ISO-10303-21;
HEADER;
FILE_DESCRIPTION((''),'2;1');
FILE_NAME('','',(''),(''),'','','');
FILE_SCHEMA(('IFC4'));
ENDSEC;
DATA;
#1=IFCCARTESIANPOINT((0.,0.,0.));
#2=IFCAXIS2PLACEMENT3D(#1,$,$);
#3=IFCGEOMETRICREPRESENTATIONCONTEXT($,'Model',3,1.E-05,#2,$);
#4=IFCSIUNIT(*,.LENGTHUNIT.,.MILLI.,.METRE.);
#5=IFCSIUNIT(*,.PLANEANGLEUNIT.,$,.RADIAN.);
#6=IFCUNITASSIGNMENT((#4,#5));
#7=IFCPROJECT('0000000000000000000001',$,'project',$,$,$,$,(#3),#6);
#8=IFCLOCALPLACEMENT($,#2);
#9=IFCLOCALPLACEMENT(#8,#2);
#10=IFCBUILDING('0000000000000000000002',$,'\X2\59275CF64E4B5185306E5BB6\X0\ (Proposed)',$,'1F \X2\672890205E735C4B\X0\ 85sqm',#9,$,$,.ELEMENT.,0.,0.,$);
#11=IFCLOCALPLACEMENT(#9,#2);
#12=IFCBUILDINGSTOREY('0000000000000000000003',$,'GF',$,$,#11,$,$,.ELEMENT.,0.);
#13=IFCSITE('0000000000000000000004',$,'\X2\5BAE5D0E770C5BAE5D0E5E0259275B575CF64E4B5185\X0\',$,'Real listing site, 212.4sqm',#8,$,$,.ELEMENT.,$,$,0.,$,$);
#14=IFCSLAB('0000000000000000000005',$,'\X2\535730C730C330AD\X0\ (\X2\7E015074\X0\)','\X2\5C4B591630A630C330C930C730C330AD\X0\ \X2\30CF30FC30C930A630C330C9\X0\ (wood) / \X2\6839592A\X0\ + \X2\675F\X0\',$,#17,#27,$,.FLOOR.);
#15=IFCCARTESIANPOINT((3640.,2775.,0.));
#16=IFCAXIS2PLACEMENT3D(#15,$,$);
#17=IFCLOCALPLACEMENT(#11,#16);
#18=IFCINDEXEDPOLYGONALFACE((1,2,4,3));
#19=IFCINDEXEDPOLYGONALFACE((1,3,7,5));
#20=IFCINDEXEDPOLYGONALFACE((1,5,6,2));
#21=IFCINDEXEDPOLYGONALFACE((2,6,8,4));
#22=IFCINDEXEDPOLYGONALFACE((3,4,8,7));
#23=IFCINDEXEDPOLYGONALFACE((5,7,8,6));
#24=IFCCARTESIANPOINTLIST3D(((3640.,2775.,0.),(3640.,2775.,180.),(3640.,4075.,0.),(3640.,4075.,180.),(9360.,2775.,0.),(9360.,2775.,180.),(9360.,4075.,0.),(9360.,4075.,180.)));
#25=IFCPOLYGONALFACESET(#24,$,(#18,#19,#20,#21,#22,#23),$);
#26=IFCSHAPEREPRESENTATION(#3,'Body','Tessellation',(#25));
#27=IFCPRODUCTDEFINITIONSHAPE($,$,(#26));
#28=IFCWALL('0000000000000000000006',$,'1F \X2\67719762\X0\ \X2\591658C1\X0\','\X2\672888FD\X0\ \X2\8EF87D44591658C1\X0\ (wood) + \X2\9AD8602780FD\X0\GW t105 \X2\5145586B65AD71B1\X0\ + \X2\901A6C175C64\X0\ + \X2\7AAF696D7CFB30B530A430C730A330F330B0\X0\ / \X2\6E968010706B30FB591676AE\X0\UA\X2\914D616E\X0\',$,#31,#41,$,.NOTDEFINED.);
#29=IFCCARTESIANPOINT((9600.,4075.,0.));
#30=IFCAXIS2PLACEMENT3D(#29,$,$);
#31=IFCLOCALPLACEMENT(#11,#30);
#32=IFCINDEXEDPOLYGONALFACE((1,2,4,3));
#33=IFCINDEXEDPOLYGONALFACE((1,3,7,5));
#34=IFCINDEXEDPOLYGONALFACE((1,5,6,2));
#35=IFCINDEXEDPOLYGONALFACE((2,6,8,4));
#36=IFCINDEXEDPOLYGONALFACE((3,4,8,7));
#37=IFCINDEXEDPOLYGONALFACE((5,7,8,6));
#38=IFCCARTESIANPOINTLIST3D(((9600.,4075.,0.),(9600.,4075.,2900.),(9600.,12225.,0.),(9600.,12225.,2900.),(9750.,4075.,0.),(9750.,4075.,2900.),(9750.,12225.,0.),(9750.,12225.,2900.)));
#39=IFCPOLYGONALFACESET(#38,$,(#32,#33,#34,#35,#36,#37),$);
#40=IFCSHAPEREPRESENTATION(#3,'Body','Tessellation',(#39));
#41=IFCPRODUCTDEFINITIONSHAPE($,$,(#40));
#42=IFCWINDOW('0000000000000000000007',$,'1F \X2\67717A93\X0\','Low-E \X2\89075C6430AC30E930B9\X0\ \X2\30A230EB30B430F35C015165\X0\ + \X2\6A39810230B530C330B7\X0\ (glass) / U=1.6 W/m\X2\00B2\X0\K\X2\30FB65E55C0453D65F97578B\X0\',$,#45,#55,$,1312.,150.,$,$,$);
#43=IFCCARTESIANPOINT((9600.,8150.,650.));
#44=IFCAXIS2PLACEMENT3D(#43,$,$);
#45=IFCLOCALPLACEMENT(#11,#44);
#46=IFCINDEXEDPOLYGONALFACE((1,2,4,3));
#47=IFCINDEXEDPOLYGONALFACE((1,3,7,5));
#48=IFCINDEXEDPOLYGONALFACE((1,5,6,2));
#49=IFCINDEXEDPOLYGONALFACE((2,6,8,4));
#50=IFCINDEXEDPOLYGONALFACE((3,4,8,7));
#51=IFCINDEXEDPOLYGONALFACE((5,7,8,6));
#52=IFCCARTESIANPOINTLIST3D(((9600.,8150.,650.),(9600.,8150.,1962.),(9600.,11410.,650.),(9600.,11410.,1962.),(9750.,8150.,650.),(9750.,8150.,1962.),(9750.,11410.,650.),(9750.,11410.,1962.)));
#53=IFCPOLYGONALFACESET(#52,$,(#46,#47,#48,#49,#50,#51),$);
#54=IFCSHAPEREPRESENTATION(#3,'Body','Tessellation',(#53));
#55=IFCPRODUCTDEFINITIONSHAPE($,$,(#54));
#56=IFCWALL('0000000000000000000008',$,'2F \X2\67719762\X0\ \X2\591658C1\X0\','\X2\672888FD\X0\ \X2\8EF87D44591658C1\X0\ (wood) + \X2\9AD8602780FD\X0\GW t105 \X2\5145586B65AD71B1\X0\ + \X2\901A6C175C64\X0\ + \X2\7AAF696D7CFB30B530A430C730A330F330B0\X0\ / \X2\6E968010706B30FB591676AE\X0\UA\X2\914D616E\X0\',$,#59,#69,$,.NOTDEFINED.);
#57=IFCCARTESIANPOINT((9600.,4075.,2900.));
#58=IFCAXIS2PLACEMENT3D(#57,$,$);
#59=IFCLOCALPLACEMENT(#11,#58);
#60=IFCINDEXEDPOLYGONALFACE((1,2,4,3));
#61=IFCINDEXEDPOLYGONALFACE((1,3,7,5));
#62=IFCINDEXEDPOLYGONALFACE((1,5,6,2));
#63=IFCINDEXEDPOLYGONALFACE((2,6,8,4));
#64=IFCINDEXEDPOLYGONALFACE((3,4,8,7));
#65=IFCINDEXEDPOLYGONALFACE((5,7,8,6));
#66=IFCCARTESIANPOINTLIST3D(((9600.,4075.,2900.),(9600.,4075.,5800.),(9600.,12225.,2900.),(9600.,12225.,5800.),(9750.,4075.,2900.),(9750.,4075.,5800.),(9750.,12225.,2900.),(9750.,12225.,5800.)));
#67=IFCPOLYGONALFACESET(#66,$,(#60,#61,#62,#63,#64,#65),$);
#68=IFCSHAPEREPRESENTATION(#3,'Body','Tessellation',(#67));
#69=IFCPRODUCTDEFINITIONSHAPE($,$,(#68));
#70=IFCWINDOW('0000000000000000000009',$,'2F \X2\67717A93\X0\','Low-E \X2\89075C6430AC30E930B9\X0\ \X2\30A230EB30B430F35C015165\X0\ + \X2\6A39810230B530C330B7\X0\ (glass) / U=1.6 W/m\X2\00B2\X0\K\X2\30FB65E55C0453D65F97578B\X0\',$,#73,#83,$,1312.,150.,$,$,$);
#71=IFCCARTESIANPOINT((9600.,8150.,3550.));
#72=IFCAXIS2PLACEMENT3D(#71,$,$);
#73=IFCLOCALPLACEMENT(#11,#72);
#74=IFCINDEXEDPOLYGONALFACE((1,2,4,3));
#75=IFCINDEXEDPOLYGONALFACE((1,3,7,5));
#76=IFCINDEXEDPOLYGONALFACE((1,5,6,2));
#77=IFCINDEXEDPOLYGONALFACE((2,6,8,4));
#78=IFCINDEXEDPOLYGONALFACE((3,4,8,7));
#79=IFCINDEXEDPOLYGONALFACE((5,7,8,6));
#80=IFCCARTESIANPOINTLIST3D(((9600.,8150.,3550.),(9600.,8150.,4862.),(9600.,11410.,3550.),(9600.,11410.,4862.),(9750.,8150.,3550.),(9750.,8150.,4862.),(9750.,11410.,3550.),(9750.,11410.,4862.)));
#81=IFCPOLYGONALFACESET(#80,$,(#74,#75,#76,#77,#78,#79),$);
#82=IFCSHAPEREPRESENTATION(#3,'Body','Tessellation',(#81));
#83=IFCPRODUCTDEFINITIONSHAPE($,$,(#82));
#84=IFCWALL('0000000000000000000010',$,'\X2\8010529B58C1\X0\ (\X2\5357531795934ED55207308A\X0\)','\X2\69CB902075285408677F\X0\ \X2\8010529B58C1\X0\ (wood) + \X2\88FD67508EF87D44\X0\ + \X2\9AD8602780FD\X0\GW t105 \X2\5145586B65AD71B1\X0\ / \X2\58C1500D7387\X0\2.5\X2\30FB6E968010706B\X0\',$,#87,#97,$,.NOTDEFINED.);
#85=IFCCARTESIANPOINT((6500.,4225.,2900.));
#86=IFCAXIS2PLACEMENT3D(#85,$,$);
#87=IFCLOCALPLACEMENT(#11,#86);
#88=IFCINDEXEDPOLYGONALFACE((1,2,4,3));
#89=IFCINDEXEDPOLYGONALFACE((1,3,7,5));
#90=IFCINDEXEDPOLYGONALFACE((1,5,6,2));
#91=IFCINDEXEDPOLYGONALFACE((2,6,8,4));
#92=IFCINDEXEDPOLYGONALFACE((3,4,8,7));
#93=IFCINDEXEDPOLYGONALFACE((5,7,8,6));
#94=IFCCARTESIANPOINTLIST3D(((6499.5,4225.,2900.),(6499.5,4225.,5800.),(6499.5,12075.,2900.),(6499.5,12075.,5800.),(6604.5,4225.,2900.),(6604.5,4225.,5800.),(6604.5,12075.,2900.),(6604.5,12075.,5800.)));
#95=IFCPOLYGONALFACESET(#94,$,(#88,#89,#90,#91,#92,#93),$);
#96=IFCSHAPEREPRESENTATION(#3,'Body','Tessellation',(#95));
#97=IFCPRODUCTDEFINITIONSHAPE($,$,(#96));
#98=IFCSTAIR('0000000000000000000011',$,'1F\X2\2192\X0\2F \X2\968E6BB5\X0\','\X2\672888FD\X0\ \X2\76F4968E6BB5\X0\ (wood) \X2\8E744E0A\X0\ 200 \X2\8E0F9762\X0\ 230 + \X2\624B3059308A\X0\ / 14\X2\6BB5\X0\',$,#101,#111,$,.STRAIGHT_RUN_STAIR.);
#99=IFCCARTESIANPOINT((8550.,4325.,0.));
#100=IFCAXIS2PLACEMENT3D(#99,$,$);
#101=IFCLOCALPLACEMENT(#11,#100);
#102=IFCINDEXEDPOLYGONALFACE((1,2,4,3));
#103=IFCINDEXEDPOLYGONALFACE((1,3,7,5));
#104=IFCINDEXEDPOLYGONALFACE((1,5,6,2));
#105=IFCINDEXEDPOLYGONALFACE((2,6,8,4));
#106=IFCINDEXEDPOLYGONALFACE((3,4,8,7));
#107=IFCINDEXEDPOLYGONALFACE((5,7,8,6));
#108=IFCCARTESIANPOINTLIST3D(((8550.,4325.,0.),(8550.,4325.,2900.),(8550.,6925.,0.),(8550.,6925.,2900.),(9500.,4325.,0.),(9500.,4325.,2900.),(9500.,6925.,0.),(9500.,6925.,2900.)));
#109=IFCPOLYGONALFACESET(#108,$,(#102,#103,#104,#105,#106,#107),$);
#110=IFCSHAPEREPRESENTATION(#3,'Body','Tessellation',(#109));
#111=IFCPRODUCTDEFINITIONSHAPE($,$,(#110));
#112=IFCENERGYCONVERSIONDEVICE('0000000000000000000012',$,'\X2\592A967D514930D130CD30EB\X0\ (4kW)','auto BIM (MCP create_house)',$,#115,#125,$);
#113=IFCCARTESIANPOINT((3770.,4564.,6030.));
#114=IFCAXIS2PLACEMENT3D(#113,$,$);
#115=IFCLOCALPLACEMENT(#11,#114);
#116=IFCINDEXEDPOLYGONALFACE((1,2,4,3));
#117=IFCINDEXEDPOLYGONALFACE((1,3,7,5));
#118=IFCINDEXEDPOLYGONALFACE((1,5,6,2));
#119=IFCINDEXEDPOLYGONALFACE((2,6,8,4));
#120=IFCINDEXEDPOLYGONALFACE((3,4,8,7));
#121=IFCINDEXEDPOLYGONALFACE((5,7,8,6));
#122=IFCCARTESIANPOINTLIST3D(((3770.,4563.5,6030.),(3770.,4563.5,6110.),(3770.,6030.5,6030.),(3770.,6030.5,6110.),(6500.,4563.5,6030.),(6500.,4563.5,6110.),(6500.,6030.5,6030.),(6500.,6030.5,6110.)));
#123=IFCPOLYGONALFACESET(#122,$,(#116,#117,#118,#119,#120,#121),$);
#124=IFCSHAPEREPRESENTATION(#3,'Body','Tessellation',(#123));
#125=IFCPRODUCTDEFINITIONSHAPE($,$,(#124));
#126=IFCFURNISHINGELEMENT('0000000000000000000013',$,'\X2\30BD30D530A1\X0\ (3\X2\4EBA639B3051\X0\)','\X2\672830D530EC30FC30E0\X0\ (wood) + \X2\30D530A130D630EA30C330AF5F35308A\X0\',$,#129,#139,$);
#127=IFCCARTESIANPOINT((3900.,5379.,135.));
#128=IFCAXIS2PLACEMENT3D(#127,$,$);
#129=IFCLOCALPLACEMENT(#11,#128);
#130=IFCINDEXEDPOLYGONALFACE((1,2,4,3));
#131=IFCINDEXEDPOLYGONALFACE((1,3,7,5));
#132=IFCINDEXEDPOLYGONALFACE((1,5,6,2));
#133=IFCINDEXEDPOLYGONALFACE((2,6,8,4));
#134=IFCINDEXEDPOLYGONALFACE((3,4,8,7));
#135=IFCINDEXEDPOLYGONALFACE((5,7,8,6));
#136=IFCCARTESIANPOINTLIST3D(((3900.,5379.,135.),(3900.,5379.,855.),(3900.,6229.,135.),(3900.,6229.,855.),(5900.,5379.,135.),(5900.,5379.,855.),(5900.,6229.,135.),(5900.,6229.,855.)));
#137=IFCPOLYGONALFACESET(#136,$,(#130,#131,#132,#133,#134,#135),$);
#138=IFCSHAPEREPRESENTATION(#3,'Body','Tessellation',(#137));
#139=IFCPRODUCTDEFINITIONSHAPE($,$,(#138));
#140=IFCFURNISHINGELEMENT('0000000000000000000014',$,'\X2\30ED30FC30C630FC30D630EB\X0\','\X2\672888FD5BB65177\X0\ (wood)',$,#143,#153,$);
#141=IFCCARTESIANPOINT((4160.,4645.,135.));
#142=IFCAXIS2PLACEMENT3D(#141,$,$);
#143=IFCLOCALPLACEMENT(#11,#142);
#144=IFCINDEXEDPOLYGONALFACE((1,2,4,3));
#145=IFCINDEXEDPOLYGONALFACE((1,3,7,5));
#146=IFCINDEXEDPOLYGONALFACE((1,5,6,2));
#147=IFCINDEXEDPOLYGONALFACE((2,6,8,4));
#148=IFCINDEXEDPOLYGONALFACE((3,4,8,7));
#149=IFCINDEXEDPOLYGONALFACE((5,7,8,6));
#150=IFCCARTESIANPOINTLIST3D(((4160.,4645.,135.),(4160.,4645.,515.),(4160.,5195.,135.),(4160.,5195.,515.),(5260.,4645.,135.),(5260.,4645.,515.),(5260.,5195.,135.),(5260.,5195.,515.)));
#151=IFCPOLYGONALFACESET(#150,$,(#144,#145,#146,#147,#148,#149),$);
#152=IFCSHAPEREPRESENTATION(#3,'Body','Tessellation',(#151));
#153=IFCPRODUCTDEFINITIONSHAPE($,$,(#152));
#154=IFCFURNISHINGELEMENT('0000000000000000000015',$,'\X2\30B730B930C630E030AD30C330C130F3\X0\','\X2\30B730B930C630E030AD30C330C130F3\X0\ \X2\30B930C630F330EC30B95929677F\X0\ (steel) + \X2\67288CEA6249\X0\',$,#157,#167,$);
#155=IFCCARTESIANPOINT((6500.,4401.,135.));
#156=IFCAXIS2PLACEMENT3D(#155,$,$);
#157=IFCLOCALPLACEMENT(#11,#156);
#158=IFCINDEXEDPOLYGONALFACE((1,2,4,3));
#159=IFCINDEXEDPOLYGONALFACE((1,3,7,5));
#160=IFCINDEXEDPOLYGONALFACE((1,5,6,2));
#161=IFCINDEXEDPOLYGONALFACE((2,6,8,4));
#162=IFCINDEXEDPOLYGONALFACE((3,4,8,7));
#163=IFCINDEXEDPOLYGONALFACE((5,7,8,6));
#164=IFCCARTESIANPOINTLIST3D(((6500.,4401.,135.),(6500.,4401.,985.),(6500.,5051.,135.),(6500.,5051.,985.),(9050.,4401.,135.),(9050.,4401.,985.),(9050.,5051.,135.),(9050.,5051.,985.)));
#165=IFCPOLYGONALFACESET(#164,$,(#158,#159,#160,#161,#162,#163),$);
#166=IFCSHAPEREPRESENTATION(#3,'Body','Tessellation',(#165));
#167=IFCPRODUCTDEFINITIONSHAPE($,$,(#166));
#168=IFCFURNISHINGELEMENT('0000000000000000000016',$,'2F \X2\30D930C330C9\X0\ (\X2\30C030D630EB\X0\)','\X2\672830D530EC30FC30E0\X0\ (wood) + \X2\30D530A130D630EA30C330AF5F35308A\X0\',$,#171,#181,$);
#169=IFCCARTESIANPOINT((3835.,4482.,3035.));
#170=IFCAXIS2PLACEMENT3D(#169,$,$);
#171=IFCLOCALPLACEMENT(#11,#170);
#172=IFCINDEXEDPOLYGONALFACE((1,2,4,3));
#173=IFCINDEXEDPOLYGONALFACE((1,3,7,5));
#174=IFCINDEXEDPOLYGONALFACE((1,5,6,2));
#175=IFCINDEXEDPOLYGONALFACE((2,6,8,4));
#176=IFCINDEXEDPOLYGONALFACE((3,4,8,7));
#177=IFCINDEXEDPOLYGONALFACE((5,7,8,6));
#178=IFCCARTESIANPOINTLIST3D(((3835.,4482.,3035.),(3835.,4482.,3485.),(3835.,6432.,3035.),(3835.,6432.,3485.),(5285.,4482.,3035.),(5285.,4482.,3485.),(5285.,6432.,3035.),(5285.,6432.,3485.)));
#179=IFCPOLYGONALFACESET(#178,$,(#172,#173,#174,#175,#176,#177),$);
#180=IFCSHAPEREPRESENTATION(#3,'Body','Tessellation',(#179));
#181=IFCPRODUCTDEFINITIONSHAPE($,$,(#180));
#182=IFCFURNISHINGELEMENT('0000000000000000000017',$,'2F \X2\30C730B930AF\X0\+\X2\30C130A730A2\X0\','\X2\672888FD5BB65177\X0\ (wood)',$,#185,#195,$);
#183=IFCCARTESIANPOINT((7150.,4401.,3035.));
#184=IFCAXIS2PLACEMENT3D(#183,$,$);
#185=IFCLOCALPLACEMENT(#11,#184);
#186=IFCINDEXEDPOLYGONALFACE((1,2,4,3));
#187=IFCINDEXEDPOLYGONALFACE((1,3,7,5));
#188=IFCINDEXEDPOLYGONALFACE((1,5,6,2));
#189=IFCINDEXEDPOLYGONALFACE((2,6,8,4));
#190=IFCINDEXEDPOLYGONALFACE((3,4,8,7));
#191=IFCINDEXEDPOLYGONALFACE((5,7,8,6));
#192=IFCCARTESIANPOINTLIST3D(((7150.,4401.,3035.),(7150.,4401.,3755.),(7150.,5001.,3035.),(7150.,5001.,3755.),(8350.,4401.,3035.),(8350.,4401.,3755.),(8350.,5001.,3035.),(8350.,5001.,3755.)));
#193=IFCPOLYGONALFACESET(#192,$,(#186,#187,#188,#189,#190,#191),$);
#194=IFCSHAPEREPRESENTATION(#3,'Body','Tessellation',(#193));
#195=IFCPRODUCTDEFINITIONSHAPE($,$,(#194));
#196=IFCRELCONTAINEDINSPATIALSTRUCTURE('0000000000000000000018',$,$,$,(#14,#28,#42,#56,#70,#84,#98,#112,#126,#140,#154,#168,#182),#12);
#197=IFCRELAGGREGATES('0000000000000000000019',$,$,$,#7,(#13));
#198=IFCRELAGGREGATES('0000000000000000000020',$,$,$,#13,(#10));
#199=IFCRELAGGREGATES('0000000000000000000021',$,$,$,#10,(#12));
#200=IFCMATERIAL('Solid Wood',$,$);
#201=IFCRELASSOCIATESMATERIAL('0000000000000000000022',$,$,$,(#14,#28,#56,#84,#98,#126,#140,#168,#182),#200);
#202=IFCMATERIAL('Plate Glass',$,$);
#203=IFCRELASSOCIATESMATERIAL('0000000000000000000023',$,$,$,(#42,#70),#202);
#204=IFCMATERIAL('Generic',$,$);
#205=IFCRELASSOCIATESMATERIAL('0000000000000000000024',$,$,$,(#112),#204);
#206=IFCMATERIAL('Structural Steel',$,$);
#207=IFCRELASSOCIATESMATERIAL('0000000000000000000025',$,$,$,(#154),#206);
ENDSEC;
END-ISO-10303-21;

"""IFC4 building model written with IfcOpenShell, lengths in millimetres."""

from ifc_helpers import new_model, si_unit, frame, frame_2d, origin, place, context, project, spatial, rectangle, extrude, material, element, fill, save


model = new_model("IFC4")

# Units and contexts
model_context = context("Model", 3, precision=1e-05, world=origin())
ifc_project = project(units=[si_unit("LENGTHUNIT", "METRE", prefix="MILLI"), si_unit("PLANEANGLEUNIT", "RADIAN")], contexts=[model_context])

# Site, building, storey
site_placement = place(None, origin())
site = spatial("IfcSite", under=ifc_project, at=site_placement, Name="宮崎県宮崎市大字島之内", ObjectType="Real listing site, 212.4sqm", CompositionType="ELEMENT", RefElevation=0.0)
building_placement = place(site_placement, origin())
building = spatial("IfcBuilding", under=site, at=building_placement, Name="大島之内の家 (Proposed)", ObjectType="1F 木造平屋 85sqm", CompositionType="ELEMENT", ElevationOfRefHeight=0.0, ElevationOfTerrain=0.0)
storey_placement = place(building_placement, origin())
storey = spatial("IfcBuildingStorey", under=building, at=storey_placement, Name="GF", CompositionType="ELEMENT", Elevation=0.0)

# Slab
ifc_material_1 = material(Name="Solid Wood")
slab_placement = place(storey_placement, frame((3640.0, 2775.0, 0.0)))
element("IfcSlab", 1, at=slab_placement, inside=storey, material=ifc_material_1, Name="南デッキ (縁側)", Description="屋外ウッドデッキ ハードウッド (wood) / 根太 + 束", PredefinedType="FLOOR", context=model_context, shape_type="SweptSolid", body=[
    extrude(rectangle(XDim=5720.0, YDim=1300.0, at=frame_2d((2860.0, 650.0))), frame((3640.0, 2775.0, 0.0)), (0.0, 0.0, 1.0), 180.0),
])

# Wall, opening, window
wall_1_placement = place(storey_placement, frame((9600.0, 4075.0, 0.0)))
wall_1 = element("IfcWall", 2, at=wall_1_placement, inside=storey, material=ifc_material_1, Name="1F 東面 外壁", Description="木製 軸組外壁 (wood) + 高性能GW t105 充填断熱 + 通気層 + 窯業系サイディング / 準耐火・外皮UA配慮", PredefinedType="NOTDEFINED", context=model_context, shape_type="SweptSolid", body=[
    extrude(rectangle(XDim=150.0, YDim=8150.0, at=frame_2d((75.0, 4075.0))), frame((9600.0, 4075.0, 0.0)), (0.0, 0.0, 1.0), 2900.0),
])
opening_1_placement = place(storey_placement, frame((9600.0, 8150.0, 650.0)))
opening_1 = element("IfcOpeningElement", 3, at=opening_1_placement, cuts=wall_1, PredefinedType="NOTDEFINED", context=model_context, shape_type="SweptSolid", body=[
    extrude(rectangle(XDim=150.0, YDim=3260.0, at=frame_2d((75.0, 1630.0))), frame((9600.0, 8150.0, 650.0)), (0.0, 0.0, 1.0), 1312.0),
])
ifc_material_2 = material(Name="Plate Glass")
window_1_placement = place(storey_placement, frame((9600.0, 8150.0, 650.0)))
window_1 = element("IfcWindow", 4, at=window_1_placement, inside=storey, material=ifc_material_2, Name="1F 東窓", Description="Low-E 複層ガラス アルゴン封入 + 樹脂サッシ (glass) / U=1.6 W/m²K・日射取得型", OverallHeight=1312.0, OverallWidth=150.0, context=model_context, shape_type="SweptSolid", body=[
    extrude(rectangle(XDim=150.0, YDim=3260.0, at=frame_2d((75.0, 1630.0))), frame((9600.0, 8150.0, 650.0)), (0.0, 0.0, 1.0), 1312.0),
])
fill(opening_1, window_1)

# Wall, opening, window
wall_2_placement = place(storey_placement, frame((9600.0, 4075.0, 2900.0)))
wall_2 = element("IfcWall", 5, at=wall_2_placement, inside=storey, material=ifc_material_1, Name="2F 東面 外壁", Description="木製 軸組外壁 (wood) + 高性能GW t105 充填断熱 + 通気層 + 窯業系サイディング / 準耐火・外皮UA配慮", PredefinedType="NOTDEFINED", context=model_context, shape_type="SweptSolid", body=[
    extrude(rectangle(XDim=150.0, YDim=8150.0, at=frame_2d((75.0, 4075.0))), frame((9600.0, 4075.0, 2900.0)), (0.0, 0.0, 1.0), 2900.0),
])
opening_2_placement = place(storey_placement, frame((9600.0, 8150.0, 3550.0)))
opening_2 = element("IfcOpeningElement", 6, at=opening_2_placement, cuts=wall_2, PredefinedType="NOTDEFINED", context=model_context, shape_type="SweptSolid", body=[
    extrude(rectangle(XDim=150.0, YDim=3260.0, at=frame_2d((75.0, 1630.0))), frame((9600.0, 8150.0, 3550.0)), (0.0, 0.0, 1.0), 1312.0),
])
window_2_placement = place(storey_placement, frame((9600.0, 8150.0, 3550.0)))
window_2 = element("IfcWindow", 7, at=window_2_placement, inside=storey, material=ifc_material_2, Name="2F 東窓", Description="Low-E 複層ガラス アルゴン封入 + 樹脂サッシ (glass) / U=1.6 W/m²K・日射取得型", OverallHeight=1312.0, OverallWidth=150.0, context=model_context, shape_type="SweptSolid", body=[
    extrude(rectangle(XDim=150.0, YDim=3260.0, at=frame_2d((75.0, 1630.0))), frame((9600.0, 8150.0, 3550.0)), (0.0, 0.0, 1.0), 1312.0),
])
fill(opening_2, window_2)

# Wall
wall_3_placement = place(storey_placement, frame((6500.0, 4225.0, 2900.0)))
element("IfcWall", 8, at=wall_3_placement, inside=storey, material=ifc_material_1, Name="耐力壁 (南北間仕切り)", Description="構造用合板 耐力壁 (wood) + 製材軸組 + 高性能GW t105 充填断熱 / 壁倍率2.5・準耐火", PredefinedType="NOTDEFINED", context=model_context, shape_type="SweptSolid", body=[
    extrude(rectangle(XDim=105.0, YDim=7850.0, at=frame_2d((52.0, 3925.0))), frame((6500.0, 4225.0, 2900.0)), (0.0, 0.0, 1.0), 2900.0),
])

# Stair
stair_placement = place(storey_placement, frame((8550.0, 4325.0, 0.0)))
element("IfcStair", 9, at=stair_placement, inside=storey, material=ifc_material_1, Name="1F→2F 階段", Description="木製 直階段 (wood) 蹴上 200 踏面 230 + 手すり / 14段", PredefinedType="STRAIGHT_RUN_STAIR", context=model_context, shape_type="SweptSolid", body=[
    extrude(rectangle(XDim=950.0, YDim=2600.0, at=frame_2d((475.0, 1300.0))), frame((8550.0, 4325.0, 0.0)), (0.0, 0.0, 1.0), 2900.0),
])

# Energy conversion device
ifc_material_3 = material(Name="Generic")
energy_conversion_device_placement = place(storey_placement, frame((3770.0, 4564.0, 6030.0)))
element("IfcEnergyConversionDevice", 10, at=energy_conversion_device_placement, inside=storey, material=ifc_material_3, Name="太陽光パネル (4kW)", Description="auto BIM (MCP create_house)", context=model_context, shape_type="SweptSolid", body=[
    extrude(rectangle(XDim=2730.0, YDim=1467.0, at=frame_2d((1365.0, 733.0))), frame((3770.0, 4564.0, 6030.0)), (0.0, 0.0, 1.0), 80.0),
])

# Furnishing elements
furnishing_1_placement = place(storey_placement, frame((3900.0, 5379.0, 135.0)))
element("IfcFurnishingElement", 11, at=furnishing_1_placement, inside=storey, material=ifc_material_1, Name="ソファ (3人掛け)", Description="木フレーム (wood) + ファブリック張り", context=model_context, shape_type="SweptSolid", body=[
    extrude(rectangle(XDim=2000.0, YDim=850.0, at=frame_2d((1000.0, 425.0))), frame((3900.0, 5379.0, 135.0)), (0.0, 0.0, 1.0), 720.0),
])
furnishing_2_placement = place(storey_placement, frame((4160.0, 4645.0, 135.0)))
element("IfcFurnishingElement", 12, at=furnishing_2_placement, inside=storey, material=ifc_material_1, Name="ローテーブル", Description="木製家具 (wood)", context=model_context, shape_type="SweptSolid", body=[
    extrude(rectangle(XDim=1100.0, YDim=550.0, at=frame_2d((550.0, 275.0))), frame((4160.0, 4645.0, 135.0)), (0.0, 0.0, 1.0), 380.0),
])
ifc_material_4 = material(Name="Structural Steel")
furnishing_3_placement = place(storey_placement, frame((6500.0, 4401.0, 135.0)))
element("IfcFurnishingElement", 13, at=furnishing_3_placement, inside=storey, material=ifc_material_4, Name="システムキッチン", Description="システムキッチン ステンレス天板 (steel) + 木質扉", context=model_context, shape_type="SweptSolid", body=[
    extrude(rectangle(XDim=2550.0, YDim=650.0, at=frame_2d((1275.0, 325.0))), frame((6500.0, 4401.0, 135.0)), (0.0, 0.0, 1.0), 850.0),
])
furnishing_4_placement = place(storey_placement, frame((3835.0, 4482.0, 3035.0)))
element("IfcFurnishingElement", 14, at=furnishing_4_placement, inside=storey, material=ifc_material_1, Name="2F ベッド (ダブル)", Description="木フレーム (wood) + ファブリック張り", context=model_context, shape_type="SweptSolid", body=[
    extrude(rectangle(XDim=1450.0, YDim=1950.0, at=frame_2d((725.0, 975.0))), frame((3835.0, 4482.0, 3035.0)), (0.0, 0.0, 1.0), 450.0),
])
furnishing_5_placement = place(storey_placement, frame((7150.0, 4401.0, 3035.0)))
element("IfcFurnishingElement", 15, at=furnishing_5_placement, inside=storey, material=ifc_material_1, Name="2F デスク+チェア", Description="木製家具 (wood)", context=model_context, shape_type="SweptSolid", body=[
    extrude(rectangle(XDim=1200.0, YDim=600.0, at=frame_2d((600.0, 300.0))), frame((7150.0, 4401.0, 3035.0)), (0.0, 0.0, 1.0), 720.0),
])

save(model, "model.ifc")
